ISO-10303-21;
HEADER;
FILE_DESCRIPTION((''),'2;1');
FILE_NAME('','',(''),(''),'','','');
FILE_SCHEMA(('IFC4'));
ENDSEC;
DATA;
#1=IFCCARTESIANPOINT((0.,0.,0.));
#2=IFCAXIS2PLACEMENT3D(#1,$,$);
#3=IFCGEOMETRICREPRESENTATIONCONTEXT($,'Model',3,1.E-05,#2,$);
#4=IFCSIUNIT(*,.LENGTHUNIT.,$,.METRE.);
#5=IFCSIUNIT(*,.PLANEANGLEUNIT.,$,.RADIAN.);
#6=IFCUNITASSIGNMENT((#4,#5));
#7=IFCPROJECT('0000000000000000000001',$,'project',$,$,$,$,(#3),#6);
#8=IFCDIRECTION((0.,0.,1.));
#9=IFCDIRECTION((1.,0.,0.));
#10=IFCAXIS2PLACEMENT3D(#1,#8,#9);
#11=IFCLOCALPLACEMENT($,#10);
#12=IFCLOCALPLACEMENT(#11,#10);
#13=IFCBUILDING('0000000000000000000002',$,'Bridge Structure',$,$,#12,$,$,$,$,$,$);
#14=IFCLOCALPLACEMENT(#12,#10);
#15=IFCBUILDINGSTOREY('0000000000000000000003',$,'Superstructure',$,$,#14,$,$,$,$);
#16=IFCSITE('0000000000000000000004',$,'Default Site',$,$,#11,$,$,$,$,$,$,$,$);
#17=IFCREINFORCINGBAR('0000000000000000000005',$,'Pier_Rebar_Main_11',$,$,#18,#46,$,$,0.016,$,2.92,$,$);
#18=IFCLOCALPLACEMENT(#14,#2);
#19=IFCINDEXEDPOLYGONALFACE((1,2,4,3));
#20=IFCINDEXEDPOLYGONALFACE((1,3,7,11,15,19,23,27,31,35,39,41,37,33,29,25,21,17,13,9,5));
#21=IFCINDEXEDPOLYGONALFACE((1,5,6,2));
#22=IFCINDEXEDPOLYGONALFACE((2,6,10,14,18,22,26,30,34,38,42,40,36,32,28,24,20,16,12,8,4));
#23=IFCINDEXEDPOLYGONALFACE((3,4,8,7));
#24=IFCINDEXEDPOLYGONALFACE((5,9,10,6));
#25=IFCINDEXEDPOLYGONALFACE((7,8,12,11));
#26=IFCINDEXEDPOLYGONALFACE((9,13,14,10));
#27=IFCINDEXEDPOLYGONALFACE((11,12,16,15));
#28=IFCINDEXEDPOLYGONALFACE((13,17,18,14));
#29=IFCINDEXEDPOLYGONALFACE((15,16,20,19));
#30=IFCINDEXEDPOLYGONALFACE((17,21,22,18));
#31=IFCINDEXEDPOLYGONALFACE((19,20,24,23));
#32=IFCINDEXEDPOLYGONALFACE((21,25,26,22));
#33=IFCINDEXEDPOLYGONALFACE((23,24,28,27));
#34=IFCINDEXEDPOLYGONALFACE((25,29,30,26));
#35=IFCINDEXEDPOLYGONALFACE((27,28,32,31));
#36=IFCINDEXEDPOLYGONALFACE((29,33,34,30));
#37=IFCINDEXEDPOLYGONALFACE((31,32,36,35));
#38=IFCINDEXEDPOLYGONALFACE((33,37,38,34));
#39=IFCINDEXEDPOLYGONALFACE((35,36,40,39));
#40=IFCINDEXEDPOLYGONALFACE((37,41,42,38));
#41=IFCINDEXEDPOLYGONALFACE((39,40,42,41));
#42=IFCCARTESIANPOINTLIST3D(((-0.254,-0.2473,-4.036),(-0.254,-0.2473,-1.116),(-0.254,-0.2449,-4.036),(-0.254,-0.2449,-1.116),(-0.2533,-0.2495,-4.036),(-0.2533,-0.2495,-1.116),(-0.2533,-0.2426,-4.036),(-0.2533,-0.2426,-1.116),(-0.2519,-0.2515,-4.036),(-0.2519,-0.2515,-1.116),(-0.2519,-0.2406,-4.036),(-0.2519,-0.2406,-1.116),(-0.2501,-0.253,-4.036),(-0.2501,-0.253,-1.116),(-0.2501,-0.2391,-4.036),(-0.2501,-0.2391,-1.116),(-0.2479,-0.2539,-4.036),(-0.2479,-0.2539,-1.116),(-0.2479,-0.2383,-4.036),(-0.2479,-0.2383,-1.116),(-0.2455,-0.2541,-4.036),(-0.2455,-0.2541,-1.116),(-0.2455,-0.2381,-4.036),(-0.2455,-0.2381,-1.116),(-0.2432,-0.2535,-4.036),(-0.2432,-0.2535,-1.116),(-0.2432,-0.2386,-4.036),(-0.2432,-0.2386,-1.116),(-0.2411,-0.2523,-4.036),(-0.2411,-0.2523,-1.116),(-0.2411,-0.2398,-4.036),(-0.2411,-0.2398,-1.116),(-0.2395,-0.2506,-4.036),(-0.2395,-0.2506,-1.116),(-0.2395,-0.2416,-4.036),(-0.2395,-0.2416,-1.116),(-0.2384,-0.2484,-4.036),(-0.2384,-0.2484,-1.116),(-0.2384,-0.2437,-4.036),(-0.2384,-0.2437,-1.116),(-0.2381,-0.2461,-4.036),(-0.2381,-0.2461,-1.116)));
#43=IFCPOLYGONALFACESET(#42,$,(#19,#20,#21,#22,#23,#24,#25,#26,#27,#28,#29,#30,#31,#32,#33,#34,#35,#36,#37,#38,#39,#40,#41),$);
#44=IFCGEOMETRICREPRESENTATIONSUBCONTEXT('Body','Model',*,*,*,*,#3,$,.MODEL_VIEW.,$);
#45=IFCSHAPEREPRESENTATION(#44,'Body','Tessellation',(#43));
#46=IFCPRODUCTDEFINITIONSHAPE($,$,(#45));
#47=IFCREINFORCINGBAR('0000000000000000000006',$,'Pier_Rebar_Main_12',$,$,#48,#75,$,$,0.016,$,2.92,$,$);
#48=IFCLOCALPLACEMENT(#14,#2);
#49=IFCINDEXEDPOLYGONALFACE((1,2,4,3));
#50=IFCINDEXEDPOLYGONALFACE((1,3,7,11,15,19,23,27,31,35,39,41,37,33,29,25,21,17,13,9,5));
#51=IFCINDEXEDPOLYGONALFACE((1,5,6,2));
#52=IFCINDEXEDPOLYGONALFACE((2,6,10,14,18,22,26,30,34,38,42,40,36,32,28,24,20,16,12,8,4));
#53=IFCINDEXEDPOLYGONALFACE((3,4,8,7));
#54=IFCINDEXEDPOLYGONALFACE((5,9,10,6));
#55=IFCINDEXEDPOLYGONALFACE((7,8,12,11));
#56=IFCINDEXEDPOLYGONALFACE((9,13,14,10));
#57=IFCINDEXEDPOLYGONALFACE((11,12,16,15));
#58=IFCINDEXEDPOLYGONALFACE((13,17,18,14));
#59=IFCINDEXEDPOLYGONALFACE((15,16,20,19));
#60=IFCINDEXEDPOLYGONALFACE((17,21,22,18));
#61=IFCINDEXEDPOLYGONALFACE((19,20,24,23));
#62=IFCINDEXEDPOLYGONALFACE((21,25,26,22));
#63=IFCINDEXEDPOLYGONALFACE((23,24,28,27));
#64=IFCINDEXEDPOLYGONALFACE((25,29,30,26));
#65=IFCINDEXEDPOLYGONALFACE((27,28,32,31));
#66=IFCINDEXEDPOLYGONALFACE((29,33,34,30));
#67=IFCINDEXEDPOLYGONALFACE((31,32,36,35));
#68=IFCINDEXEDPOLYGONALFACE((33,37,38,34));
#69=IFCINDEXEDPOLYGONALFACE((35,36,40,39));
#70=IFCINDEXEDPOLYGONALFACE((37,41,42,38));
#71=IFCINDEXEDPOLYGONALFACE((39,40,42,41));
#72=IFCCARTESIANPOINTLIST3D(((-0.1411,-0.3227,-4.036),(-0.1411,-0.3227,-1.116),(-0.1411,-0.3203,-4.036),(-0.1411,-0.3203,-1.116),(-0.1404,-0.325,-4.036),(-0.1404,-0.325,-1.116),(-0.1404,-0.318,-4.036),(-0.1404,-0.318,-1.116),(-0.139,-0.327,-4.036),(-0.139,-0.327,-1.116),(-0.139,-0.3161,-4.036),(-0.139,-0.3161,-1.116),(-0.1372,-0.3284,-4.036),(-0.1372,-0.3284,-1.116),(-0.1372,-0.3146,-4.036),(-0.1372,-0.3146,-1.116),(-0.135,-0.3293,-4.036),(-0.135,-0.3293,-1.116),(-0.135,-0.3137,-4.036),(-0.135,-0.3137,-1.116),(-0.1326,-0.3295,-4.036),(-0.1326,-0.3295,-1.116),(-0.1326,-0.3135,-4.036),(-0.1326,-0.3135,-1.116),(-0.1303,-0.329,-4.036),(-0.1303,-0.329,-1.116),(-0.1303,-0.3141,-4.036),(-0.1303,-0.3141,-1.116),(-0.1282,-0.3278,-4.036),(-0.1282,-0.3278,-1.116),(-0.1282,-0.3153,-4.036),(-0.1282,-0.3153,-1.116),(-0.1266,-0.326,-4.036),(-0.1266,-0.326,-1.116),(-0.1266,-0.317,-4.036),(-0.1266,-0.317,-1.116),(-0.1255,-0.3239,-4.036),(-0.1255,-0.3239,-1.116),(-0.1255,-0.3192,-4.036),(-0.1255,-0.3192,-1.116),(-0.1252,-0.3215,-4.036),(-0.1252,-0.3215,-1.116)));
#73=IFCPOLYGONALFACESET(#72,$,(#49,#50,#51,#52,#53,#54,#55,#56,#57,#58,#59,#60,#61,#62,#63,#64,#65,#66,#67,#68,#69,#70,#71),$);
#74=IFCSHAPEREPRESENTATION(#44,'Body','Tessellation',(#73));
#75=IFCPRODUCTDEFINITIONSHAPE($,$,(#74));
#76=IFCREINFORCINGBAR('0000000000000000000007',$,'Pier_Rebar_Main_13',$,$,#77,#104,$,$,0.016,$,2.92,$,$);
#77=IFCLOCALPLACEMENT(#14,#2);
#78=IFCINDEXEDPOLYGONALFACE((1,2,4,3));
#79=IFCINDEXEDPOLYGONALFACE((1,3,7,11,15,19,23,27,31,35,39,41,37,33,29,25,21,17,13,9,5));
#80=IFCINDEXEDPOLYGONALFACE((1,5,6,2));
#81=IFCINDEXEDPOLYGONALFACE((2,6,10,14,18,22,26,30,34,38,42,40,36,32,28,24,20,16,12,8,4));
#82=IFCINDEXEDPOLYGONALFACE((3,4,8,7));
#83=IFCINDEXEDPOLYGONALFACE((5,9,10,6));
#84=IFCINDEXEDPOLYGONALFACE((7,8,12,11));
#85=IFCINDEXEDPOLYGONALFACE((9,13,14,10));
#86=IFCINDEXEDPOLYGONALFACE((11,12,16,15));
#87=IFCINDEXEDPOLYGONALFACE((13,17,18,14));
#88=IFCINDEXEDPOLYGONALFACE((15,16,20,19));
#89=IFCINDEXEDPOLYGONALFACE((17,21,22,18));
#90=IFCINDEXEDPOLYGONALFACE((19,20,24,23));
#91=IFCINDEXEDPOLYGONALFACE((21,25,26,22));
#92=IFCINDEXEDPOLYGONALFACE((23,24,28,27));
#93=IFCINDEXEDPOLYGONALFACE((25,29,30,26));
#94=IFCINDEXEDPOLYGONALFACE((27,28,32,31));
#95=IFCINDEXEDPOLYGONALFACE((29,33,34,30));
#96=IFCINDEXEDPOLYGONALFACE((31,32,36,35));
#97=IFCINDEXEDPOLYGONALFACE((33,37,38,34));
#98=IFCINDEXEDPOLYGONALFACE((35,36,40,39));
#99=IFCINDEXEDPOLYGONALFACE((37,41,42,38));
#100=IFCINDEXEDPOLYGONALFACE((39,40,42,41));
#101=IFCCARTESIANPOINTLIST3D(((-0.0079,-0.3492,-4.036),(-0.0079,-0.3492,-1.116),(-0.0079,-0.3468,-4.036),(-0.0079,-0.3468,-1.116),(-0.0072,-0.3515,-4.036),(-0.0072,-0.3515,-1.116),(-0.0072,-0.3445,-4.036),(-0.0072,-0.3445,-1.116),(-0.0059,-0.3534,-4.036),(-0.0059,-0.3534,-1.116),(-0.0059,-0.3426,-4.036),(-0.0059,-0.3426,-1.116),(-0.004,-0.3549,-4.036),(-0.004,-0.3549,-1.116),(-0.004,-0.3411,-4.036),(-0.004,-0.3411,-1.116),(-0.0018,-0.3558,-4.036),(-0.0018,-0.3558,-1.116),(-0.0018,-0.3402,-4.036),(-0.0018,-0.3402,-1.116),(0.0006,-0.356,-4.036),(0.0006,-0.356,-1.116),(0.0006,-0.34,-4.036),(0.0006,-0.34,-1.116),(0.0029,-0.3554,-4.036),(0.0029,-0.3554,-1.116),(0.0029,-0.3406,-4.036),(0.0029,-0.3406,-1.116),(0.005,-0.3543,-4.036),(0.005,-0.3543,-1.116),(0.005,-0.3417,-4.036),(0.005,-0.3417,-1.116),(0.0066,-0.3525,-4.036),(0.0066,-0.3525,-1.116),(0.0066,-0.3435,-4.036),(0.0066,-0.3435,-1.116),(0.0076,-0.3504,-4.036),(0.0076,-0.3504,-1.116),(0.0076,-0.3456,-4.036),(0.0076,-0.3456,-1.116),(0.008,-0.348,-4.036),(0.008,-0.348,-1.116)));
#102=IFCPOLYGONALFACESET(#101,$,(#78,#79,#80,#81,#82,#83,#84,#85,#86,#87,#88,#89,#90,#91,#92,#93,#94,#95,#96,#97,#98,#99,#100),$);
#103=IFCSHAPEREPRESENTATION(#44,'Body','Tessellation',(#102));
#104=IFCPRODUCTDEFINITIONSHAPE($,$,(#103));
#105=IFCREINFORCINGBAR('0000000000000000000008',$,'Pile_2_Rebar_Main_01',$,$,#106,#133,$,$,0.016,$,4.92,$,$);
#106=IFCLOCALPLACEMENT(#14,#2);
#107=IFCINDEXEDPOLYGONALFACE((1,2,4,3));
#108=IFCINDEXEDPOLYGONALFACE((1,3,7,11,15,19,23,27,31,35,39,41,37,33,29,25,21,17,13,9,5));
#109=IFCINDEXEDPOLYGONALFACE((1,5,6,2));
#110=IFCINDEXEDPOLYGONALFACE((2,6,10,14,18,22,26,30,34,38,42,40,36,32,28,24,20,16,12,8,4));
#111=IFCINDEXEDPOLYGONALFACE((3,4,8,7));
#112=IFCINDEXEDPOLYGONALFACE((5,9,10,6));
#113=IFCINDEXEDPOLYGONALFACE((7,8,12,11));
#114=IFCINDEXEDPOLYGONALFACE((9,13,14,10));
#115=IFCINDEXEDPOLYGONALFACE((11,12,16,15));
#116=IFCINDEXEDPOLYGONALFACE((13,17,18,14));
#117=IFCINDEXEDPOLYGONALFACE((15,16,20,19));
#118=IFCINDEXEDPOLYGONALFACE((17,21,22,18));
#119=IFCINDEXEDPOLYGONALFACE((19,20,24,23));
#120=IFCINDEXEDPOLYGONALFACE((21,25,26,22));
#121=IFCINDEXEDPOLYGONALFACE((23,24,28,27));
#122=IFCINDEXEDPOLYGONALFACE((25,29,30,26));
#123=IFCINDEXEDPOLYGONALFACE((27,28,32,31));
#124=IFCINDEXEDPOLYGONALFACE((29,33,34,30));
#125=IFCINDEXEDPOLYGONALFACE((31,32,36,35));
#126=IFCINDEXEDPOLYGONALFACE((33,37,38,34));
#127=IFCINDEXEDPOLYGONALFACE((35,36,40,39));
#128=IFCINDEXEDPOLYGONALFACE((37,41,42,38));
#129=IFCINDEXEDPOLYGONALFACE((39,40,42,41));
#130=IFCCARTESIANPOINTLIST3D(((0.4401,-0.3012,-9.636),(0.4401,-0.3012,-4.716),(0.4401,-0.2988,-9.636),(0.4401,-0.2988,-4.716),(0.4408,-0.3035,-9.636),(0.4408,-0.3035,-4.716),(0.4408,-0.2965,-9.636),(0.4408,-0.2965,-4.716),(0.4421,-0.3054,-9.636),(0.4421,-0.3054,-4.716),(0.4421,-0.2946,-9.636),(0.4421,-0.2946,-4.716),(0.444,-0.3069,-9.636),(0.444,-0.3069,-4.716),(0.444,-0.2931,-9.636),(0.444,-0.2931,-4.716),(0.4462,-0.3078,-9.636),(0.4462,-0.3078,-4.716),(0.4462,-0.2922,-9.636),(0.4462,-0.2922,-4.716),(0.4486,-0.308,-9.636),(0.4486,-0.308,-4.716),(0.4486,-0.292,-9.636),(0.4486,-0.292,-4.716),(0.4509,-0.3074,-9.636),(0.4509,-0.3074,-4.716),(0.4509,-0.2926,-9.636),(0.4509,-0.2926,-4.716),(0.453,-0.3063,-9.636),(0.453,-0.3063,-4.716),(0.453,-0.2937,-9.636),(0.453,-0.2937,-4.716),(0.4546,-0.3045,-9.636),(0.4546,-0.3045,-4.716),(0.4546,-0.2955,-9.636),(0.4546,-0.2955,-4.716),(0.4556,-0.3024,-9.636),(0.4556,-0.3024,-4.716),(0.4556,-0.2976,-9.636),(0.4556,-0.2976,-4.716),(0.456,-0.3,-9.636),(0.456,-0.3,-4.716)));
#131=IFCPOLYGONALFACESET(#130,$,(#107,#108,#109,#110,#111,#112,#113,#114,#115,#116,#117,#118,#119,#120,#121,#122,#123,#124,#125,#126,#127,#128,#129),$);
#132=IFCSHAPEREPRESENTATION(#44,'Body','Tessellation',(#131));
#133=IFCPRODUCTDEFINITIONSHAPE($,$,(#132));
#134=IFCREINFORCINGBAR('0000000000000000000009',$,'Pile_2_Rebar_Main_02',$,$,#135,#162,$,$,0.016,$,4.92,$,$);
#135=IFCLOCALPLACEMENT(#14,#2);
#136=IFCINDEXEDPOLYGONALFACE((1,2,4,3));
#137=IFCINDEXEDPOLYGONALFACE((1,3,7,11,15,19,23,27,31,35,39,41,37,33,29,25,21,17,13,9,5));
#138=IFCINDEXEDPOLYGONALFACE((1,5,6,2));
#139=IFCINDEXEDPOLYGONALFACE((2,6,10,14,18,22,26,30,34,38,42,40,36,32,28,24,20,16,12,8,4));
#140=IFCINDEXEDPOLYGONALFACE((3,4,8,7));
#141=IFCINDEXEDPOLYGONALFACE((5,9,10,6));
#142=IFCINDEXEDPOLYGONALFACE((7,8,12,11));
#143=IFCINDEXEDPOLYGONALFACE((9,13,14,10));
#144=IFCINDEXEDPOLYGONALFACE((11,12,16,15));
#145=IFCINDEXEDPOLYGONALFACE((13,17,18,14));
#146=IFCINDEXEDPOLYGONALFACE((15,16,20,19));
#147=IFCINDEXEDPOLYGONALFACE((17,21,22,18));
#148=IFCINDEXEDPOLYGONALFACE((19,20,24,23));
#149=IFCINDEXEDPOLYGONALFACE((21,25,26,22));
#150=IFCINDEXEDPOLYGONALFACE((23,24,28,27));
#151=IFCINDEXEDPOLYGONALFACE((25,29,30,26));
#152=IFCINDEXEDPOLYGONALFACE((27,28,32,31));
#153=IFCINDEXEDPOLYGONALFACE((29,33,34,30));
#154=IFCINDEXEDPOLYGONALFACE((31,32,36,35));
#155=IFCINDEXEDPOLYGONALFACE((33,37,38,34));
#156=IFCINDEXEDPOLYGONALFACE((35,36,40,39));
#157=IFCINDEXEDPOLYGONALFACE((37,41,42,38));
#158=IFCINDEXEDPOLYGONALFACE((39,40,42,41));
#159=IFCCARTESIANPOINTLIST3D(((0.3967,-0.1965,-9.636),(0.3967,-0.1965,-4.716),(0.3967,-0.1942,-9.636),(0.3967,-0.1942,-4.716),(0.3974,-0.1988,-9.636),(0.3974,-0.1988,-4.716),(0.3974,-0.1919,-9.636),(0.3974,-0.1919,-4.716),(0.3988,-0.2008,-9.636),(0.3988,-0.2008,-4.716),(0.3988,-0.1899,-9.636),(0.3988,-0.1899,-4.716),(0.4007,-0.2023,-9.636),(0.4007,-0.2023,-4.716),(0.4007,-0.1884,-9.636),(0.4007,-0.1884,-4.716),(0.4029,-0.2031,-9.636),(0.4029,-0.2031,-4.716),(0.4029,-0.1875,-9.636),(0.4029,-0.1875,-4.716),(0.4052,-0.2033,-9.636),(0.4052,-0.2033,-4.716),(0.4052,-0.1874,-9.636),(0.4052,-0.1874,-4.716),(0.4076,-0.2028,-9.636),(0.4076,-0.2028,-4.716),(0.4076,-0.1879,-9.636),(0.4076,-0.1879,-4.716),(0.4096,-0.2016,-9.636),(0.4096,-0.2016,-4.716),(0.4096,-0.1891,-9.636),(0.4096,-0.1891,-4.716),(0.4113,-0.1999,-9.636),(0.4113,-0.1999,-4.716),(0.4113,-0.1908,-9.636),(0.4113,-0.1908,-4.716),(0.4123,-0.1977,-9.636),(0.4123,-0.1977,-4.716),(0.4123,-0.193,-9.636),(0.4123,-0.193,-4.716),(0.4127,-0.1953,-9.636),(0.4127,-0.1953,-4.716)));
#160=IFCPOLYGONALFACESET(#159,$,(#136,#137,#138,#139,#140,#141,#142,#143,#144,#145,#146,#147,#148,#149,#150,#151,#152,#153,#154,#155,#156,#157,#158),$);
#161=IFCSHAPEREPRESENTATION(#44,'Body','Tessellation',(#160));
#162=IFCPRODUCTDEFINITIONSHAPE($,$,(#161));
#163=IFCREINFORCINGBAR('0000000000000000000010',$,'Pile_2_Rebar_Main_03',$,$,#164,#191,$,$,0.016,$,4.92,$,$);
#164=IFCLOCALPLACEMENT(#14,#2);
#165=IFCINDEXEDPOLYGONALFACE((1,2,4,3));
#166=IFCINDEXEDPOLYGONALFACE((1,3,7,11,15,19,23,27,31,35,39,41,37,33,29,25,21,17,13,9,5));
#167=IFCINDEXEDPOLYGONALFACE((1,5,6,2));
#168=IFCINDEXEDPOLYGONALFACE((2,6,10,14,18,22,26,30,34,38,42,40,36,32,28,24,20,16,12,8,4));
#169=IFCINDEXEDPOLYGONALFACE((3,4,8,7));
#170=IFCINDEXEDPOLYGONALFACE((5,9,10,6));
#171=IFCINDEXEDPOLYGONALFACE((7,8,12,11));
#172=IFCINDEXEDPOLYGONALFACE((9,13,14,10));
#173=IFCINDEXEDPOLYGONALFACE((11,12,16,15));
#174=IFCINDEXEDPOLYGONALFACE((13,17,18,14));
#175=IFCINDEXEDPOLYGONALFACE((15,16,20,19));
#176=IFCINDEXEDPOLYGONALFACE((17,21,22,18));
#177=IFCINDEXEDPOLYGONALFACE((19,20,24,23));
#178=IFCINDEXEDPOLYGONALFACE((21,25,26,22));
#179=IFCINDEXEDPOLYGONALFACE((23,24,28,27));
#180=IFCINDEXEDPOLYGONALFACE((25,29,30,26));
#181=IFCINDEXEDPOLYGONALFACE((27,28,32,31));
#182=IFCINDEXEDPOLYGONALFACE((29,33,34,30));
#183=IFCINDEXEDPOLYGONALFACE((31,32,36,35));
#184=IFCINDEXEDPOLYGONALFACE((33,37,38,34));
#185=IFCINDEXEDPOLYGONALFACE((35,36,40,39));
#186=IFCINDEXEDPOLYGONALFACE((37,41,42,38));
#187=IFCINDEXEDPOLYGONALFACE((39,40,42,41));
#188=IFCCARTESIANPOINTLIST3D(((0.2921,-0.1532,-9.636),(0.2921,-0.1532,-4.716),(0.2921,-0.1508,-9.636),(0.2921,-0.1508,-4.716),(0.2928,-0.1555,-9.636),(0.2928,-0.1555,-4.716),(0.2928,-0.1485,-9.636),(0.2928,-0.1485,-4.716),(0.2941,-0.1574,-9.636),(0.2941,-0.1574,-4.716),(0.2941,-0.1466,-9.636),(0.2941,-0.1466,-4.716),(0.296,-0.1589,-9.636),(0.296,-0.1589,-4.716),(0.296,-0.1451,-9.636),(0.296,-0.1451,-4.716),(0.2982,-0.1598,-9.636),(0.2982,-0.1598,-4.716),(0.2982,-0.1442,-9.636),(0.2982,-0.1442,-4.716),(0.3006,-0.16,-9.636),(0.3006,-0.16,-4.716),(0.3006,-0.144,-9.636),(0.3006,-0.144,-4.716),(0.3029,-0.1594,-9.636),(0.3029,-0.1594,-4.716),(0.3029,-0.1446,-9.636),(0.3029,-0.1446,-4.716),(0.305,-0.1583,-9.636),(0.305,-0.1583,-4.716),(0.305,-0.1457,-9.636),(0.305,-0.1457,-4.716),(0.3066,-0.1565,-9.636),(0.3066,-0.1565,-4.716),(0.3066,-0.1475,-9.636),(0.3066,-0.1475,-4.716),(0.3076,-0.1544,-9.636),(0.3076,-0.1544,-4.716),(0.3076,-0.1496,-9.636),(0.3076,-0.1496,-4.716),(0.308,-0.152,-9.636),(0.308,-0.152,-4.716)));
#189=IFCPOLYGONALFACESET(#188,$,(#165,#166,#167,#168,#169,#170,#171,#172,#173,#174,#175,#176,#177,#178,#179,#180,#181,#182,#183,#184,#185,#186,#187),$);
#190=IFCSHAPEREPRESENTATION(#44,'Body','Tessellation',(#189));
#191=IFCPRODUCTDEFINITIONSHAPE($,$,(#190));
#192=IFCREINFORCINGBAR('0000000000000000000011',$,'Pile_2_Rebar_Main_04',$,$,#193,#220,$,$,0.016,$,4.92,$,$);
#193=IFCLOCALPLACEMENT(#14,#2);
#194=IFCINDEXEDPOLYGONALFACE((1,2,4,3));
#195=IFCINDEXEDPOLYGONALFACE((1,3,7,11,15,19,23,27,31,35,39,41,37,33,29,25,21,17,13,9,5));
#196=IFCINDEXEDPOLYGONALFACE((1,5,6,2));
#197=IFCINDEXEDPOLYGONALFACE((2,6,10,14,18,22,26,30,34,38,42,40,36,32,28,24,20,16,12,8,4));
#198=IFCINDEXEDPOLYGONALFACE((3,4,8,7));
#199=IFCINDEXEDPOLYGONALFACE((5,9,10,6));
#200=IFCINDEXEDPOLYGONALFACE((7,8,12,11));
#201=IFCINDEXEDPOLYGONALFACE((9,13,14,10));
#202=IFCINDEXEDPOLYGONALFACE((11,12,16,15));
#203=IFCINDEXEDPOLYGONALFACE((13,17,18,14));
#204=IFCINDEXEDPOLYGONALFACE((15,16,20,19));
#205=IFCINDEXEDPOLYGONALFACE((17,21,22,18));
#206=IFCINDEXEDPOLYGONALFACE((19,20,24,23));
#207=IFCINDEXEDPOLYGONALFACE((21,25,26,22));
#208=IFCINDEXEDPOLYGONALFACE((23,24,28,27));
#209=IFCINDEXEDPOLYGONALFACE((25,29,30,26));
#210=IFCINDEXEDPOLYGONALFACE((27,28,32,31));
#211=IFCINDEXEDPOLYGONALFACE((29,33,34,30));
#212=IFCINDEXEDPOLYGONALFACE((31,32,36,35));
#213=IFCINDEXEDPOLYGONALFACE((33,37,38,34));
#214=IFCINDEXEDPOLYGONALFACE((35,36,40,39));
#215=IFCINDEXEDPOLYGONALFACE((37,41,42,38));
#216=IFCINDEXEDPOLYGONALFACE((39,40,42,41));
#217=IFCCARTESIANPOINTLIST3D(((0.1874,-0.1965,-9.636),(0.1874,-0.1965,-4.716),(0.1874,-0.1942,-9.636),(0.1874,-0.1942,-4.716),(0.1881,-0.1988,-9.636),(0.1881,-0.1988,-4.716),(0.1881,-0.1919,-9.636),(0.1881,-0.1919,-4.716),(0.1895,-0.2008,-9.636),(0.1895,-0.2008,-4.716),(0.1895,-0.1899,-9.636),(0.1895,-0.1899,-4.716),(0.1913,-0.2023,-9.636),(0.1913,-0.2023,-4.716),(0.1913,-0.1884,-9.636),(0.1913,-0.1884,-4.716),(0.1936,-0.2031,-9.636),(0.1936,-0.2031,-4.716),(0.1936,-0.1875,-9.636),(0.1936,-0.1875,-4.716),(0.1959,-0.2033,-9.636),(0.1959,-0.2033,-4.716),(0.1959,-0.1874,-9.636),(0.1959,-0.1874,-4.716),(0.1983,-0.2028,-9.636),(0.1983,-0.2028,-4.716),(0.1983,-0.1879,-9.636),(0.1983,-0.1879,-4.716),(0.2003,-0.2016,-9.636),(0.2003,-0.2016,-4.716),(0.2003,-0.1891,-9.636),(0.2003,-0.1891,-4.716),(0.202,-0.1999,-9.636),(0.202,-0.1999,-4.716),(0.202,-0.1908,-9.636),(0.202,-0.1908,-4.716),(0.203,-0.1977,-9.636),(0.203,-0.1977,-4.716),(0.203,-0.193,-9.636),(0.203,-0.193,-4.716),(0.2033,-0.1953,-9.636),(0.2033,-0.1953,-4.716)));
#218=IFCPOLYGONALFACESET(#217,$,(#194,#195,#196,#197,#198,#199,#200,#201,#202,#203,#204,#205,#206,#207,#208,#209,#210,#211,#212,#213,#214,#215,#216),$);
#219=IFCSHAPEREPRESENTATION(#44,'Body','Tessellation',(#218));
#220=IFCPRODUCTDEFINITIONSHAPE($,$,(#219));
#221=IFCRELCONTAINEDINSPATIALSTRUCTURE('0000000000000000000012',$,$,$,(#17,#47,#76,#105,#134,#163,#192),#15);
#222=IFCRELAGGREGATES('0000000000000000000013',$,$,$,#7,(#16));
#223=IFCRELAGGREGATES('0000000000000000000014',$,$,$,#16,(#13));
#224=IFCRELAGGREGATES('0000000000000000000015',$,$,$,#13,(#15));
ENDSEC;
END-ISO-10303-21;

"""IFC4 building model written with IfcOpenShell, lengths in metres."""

from ifc_helpers import new_model, si_unit, frame, origin, origin_with_axes, origin_2d_with_axis, place, context, subcontext, project, spatial, circle, extrude, element, save


model = new_model("IFC4")

# Units and contexts
model_context = context("Model", 3, precision=1e-05, world=origin())
body_context = subcontext(model_context, "Body", "Model", "MODEL_VIEW")
ifc_project = project(units=[si_unit("LENGTHUNIT", "METRE"), si_unit("PLANEANGLEUNIT", "RADIAN")], contexts=[model_context])

# Site, building, storey
site_placement = place(None, origin_with_axes())
site = spatial("IfcSite", under=ifc_project, at=site_placement, Name="Default Site")
building_placement = place(site_placement, origin_with_axes())
building = spatial("IfcBuilding", under=site, at=building_placement, Name="Bridge Structure")
storey_placement = place(building_placement, origin_with_axes())
storey = spatial("IfcBuildingStorey", under=building, at=storey_placement, Name="Superstructure")

# Reinforcing bars
for number, where, z_axis, x_axis, name in (
    (1, (-0.2461, -0.2461, -4.036), (0.0, 0.0, 1.0), (1.0, 0.0, 0.0), "Pier_Rebar_Main_11"),
    (2, (-0.1332, -0.3215, -4.036), (0.0, 0.0, 1.0), (1.0, 0.0, 0.0), "Pier_Rebar_Main_12"),
    (3, (0.0, -0.348, -4.036), (0.0, 0.0, 1.0), (1.0, 0.0, 0.0), "Pier_Rebar_Main_13"),
):
    element("IfcReinforcingBar", number, at=place(storey_placement, frame(where, z_axis=z_axis, x_axis=x_axis)), inside=storey, Name=name, BarLength=2.92, NominalDiameter=0.016, context=body_context, shape_type="SweptSolid", body=[
        extrude(circle(Radius=0.008, at=origin_2d_with_axis()), origin_with_axes(), (0.0, 0.0, 1.0), 2.92),
    ])
for number, where, z_axis, x_axis, name in (
    (4, (0.448, -0.3, -9.636), (0.0, 0.0, 1.0), (1.0, 0.0, 0.0), "Pile_2_Rebar_Main_01"),
    (5, (0.4047, -0.1953, -9.636), (0.0, 0.0, 1.0), (1.0, 0.0, 0.0), "Pile_2_Rebar_Main_02"),
    (6, (0.3, -0.152, -9.636), (0.0, 0.0, 1.0), (1.0, 0.0, 0.0), "Pile_2_Rebar_Main_03"),
    (7, (0.1953, -0.1953, -9.636), (0.0, 0.0, 1.0), (1.0, 0.0, 0.0), "Pile_2_Rebar_Main_04"),
):
    element("IfcReinforcingBar", number, at=place(storey_placement, frame(where, z_axis=z_axis, x_axis=x_axis)), inside=storey, Name=name, BarLength=4.92, NominalDiameter=0.016, context=body_context, shape_type="SweptSolid", body=[
        extrude(circle(Radius=0.008, at=origin_2d_with_axis()), origin_with_axes(), (0.0, 0.0, 1.0), 4.92),
    ])

save(model, "model.ifc")
